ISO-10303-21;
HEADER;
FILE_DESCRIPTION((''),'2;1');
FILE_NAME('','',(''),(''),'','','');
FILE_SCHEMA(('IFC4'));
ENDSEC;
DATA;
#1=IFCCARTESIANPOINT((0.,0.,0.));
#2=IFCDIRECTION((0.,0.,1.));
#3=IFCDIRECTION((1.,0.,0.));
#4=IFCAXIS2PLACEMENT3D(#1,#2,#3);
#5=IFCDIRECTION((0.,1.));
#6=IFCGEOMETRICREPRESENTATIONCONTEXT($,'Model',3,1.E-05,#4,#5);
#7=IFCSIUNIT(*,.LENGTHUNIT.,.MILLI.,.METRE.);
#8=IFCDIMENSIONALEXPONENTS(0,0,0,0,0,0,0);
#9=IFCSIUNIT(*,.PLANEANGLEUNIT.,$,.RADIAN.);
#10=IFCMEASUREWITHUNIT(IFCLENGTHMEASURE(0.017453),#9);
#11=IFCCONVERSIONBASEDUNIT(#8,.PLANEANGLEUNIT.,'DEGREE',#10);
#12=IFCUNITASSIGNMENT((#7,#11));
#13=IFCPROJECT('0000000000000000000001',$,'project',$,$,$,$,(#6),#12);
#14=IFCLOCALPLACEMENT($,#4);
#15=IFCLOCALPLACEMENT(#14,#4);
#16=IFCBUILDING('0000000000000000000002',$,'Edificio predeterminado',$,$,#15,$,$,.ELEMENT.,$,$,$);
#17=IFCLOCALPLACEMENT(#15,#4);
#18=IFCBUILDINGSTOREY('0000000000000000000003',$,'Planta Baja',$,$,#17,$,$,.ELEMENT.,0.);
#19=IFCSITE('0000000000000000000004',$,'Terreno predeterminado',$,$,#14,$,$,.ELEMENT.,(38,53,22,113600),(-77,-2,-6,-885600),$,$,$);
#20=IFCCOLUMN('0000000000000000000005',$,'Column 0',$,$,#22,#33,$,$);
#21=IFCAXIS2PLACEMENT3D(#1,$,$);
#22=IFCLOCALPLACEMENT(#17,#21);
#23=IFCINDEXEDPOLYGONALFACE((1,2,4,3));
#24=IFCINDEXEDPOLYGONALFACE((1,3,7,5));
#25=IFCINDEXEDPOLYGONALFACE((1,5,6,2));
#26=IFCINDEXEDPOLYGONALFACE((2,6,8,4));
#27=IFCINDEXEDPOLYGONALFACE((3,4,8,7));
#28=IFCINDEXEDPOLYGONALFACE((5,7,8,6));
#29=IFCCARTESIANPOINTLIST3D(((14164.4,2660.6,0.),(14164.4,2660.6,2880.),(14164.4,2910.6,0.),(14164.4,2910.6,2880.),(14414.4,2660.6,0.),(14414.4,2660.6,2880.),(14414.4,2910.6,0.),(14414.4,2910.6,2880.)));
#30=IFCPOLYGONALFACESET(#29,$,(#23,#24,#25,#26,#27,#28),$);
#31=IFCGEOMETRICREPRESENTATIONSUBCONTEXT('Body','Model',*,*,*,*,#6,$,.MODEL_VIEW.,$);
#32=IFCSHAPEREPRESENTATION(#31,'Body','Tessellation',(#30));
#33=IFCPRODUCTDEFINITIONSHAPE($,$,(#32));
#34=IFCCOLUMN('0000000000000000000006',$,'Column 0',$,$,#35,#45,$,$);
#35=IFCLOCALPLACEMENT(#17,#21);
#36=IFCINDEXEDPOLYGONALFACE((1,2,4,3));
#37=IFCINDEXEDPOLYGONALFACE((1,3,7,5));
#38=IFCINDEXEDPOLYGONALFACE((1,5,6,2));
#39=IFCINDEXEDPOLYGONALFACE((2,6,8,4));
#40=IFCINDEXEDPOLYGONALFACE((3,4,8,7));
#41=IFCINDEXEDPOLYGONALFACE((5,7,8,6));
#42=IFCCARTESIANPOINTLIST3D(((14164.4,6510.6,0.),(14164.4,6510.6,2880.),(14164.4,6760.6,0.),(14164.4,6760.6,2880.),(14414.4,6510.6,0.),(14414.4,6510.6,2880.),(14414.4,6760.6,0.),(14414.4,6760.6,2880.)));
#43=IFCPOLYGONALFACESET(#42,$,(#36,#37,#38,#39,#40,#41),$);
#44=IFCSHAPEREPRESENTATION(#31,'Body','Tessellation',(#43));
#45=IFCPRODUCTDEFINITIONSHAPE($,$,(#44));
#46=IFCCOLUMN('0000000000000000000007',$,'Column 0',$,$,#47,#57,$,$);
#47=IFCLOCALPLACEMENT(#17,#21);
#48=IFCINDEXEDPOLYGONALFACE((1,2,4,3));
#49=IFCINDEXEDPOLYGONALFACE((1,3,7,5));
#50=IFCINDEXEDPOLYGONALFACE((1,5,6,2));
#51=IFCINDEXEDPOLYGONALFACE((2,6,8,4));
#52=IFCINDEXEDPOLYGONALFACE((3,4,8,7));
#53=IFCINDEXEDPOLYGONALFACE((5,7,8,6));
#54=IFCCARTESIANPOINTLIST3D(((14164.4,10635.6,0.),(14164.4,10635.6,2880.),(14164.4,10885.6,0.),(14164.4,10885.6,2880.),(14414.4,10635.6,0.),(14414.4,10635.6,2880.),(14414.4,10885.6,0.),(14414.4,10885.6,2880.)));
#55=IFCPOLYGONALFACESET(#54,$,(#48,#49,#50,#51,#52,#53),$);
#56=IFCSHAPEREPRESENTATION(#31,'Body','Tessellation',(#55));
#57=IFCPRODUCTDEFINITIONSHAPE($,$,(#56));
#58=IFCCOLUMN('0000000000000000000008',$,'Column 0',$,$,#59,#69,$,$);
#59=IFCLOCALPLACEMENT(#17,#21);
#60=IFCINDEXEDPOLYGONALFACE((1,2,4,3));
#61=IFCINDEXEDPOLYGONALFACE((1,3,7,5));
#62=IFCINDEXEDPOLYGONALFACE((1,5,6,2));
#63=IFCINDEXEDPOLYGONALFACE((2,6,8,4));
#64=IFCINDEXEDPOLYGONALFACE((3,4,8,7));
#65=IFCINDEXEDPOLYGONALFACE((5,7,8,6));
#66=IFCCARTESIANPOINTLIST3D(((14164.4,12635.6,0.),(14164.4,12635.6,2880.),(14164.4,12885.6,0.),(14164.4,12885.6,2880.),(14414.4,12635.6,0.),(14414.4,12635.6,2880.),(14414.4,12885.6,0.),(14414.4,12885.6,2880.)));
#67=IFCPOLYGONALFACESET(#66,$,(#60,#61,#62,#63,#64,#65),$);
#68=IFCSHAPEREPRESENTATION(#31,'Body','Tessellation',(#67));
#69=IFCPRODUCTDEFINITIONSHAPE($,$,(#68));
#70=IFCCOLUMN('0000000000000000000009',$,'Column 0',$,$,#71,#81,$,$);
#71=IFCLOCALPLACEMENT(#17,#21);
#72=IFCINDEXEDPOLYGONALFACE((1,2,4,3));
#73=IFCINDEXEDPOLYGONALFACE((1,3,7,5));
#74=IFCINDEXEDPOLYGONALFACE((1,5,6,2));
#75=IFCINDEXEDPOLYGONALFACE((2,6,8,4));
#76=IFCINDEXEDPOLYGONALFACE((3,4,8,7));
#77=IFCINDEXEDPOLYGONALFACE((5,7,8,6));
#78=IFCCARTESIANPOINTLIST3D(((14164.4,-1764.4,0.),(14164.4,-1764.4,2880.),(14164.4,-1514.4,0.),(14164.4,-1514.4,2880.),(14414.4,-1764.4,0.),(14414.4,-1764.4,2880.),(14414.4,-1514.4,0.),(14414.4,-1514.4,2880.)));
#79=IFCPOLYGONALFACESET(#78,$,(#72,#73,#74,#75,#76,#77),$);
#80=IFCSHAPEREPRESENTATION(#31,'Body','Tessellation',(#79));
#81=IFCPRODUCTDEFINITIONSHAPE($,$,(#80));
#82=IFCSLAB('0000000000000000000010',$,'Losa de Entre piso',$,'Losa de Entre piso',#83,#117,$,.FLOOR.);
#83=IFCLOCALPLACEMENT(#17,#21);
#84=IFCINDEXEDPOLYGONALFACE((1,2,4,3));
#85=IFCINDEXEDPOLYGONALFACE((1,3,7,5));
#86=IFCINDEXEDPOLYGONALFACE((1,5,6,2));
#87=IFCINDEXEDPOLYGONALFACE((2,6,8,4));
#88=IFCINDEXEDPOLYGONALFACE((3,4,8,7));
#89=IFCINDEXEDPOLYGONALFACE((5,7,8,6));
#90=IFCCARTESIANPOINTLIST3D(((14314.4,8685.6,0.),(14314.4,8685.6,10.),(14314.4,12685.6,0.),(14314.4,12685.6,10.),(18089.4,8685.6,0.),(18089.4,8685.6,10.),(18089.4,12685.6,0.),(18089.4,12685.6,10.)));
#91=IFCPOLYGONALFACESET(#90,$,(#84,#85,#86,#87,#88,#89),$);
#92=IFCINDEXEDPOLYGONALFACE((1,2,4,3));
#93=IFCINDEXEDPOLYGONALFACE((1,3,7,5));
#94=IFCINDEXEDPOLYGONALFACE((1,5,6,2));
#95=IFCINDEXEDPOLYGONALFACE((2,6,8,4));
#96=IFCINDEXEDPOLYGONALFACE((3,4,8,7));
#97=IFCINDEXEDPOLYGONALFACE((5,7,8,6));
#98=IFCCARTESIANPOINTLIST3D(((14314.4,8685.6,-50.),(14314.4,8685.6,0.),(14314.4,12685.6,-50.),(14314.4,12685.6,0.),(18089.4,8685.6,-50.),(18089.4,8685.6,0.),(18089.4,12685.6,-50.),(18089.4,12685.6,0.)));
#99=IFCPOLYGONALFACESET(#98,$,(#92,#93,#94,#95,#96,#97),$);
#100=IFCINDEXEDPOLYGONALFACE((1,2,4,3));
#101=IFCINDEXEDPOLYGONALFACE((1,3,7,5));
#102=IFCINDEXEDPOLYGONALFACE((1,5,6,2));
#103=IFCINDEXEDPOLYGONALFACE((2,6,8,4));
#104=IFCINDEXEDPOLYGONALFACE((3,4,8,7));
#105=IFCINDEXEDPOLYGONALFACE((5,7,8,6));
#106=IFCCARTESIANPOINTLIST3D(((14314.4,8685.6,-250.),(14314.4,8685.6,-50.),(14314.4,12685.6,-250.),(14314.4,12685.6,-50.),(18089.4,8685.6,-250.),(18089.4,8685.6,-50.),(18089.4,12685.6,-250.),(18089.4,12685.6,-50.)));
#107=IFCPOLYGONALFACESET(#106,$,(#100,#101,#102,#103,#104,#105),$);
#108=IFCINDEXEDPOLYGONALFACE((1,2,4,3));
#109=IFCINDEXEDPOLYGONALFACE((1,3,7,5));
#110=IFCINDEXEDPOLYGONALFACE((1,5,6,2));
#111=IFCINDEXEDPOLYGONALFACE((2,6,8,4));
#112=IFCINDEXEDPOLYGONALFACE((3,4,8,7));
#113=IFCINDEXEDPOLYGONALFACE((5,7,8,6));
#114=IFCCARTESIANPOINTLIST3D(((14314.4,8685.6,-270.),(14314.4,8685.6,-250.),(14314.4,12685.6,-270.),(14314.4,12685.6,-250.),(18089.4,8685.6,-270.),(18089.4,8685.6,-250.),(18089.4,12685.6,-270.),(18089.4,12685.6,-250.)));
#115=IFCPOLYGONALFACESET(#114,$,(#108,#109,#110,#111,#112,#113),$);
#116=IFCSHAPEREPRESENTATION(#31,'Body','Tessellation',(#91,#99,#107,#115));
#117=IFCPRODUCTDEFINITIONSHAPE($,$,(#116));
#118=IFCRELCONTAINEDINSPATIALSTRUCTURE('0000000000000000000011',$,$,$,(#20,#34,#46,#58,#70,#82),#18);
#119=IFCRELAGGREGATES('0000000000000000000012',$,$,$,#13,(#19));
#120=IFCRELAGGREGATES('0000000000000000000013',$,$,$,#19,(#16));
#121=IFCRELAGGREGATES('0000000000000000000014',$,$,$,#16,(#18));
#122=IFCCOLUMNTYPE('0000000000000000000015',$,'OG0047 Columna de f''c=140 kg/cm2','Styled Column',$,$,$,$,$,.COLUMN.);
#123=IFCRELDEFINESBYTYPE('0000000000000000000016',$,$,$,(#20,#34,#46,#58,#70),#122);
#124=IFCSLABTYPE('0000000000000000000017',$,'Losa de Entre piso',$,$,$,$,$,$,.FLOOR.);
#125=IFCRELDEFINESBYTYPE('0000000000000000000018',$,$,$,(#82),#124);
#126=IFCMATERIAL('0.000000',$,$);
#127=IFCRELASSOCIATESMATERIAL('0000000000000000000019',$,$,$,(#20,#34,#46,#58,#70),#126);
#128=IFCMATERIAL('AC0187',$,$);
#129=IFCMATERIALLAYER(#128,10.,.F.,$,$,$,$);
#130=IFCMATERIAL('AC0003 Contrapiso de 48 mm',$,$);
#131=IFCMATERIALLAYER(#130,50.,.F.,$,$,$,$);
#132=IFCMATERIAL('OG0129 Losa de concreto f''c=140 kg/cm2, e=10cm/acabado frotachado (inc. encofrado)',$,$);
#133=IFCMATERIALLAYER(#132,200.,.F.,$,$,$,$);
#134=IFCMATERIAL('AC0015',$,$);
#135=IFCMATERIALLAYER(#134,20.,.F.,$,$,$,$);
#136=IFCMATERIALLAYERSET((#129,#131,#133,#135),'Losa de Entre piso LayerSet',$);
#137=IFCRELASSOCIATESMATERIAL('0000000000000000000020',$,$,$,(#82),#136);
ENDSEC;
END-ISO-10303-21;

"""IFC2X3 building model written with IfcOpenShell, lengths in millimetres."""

from ifc_helpers import new_model, entity, si_unit, converted_unit, direction, frame, origin_with_axes, place, context, subcontext, project, spatial, polyline, outline, extrude, material, layer, layer_set, layer_usage, type_object, element, save


model = new_model("IFC2X3")

# Units and contexts
model_context = context("Model", 3, precision=1e-05, world=origin_with_axes(), true_north=direction((0.0, 1.0)))
body_context = subcontext(model_context, "Body", "Model", "MODEL_VIEW")
ifc_project = project(units=[si_unit("LENGTHUNIT", "METRE", prefix="MILLI"), converted_unit("PLANEANGLEUNIT", "DEGREE", entity("IfcLengthMeasure", 0.017453), si_unit("PLANEANGLEUNIT", "RADIAN"), dimensions=[0, 0, 0, 0, 0, 0, 0])], contexts=[model_context])

# Site, building, storey
site_placement = place(None, origin_with_axes())
site = spatial("IfcSite", under=ifc_project, at=site_placement, Name="Terreno predeterminado", CompositionType="ELEMENT", RefLatitude=(38, 53, 22, 113600), RefLongitude=(-77, -2, -6, -885600))
building_placement = place(site_placement, origin_with_axes())
building = spatial("IfcBuilding", under=site, at=building_placement, Name="Edificio predeterminado", CompositionType="ELEMENT")
storey_placement = place(building_placement, origin_with_axes())
storey = spatial("IfcBuildingStorey", under=building, at=storey_placement, Name="Planta Baja", CompositionType="ELEMENT", Elevation=0.0)

# Columns
ifc_material_1 = material(Name="0.000000")
column_type = type_object("IfcColumnType", Name="OG0047 Columna de f'c=140 kg/cm2", Description="Styled Column", PredefinedType="COLUMN")
for number, where, z_axis, x_axis, name in (
    (1, (14289.4, 2785.6, 0.0), (0.0, 0.0, 1.0), (1.0, 0.0, 0.0), "Column 0"),
    (2, (14289.4, 6635.6, 0.0), (0.0, 0.0, 1.0), (1.0, 0.0, 0.0), "Column 0"),
    (3, (14289.4, 10760.6, 0.0), (0.0, 0.0, 1.0), (1.0, 0.0, 0.0), "Column 0"),
    (4, (14289.4, 12760.6, 0.0), (0.0, 0.0, 1.0), (1.0, 0.0, 0.0), "Column 0"),
    (5, (14289.4, -1639.4, 0.0), (0.0, 0.0, 1.0), (1.0, 0.0, 0.0), "Column 0"),
):
    element("IfcColumn", number, at=place(storey_placement, frame(where, z_axis=z_axis, x_axis=x_axis)), inside=storey, type_object=column_type, material=ifc_material_1, Name=name, context=body_context, shape_type="SweptSolid", body=[
        extrude(outline(polyline([(-125.0, -125.0), (125.0, -125.0), (125.0, 125.0), (-125.0, 125.0), (-125.0, -125.0)])), origin_with_axes(), (0.0, 0.0, 1.0), 2880.0),
    ])

# Slab
ifc_material_2 = material(Name="AC0187")
ifc_layer_1 = layer(ifc_material_2, 10.0, ventilated=False)
ifc_material_3 = material(Name="AC0003 Contrapiso de 48 mm")
ifc_layer_2 = layer(ifc_material_3, 50.0, ventilated=False)
ifc_material_4 = material(Name="OG0129 Losa de concreto f'c=140 kg/cm2, e=10cm/acabado frotachado (inc. encofrado)")
ifc_layer_3 = layer(ifc_material_4, 200.0, ventilated=False)
ifc_material_5 = material(Name="AC0015")
ifc_layer_4 = layer(ifc_material_5, 20.0, ventilated=False)
ifc_layer_set_1 = layer_set([ifc_layer_1, ifc_layer_2, ifc_layer_3, ifc_layer_4], Name="Losa de Entre piso LayerSet")
ifc_layer_usage_1 = layer_usage(ifc_layer_set_1, "AXIS3", "NEGATIVE", 0.0)
slab_type = type_object("IfcSlabType", Name="Losa de Entre piso", PredefinedType="FLOOR")
slab_1_placement = place(storey_placement, origin_with_axes())
element("IfcSlab", 6, at=slab_1_placement, inside=storey, type_object=slab_type, material=ifc_layer_usage_1, Name="Losa de Entre piso", ObjectType="Losa de Entre piso", PredefinedType="FLOOR", context=body_context, shape_type="SweptSolid", body=[
    extrude(outline(polyline([(0.0, 4000.0), (3775.0, 4000.0), (3775.0, 0.0), (0.0, 0.0), (0.0, 4000.0)])), frame((14314.4, 12685.6, 0.0), z_axis=(0.0, 0.0, -1.0), x_axis=(1.0, 0.0, 0.0)), (0.0, 0.0, -1.0), 10.0),
    extrude(outline(polyline([(0.0, 4000.0), (3775.0, 4000.0), (3775.0, 0.0), (0.0, 0.0), (0.0, 4000.0)])), frame((14314.4, 12685.6, -50.0), z_axis=(0.0, 0.0, -1.0), x_axis=(1.0, 0.0, 0.0)), (0.0, 0.0, -1.0), 50.0),
    extrude(outline(polyline([(0.0, 4000.0), (3775.0, 4000.0), (3775.0, 0.0), (0.0, 0.0), (0.0, 4000.0)])), frame((14314.4, 12685.6, -250.0), z_axis=(0.0, 0.0, -1.0), x_axis=(1.0, 0.0, 0.0)), (0.0, 0.0, -1.0), 200.0),
    extrude(outline(polyline([(0.0, 4000.0), (3775.0, 4000.0), (3775.0, 0.0), (0.0, 0.0), (0.0, 4000.0)])), frame((14314.4, 12685.6, -270.0), z_axis=(0.0, 0.0, -1.0), x_axis=(1.0, 0.0, 0.0)), (0.0, 0.0, -1.0), 20.0),
])

save(model, "model.ifc")
